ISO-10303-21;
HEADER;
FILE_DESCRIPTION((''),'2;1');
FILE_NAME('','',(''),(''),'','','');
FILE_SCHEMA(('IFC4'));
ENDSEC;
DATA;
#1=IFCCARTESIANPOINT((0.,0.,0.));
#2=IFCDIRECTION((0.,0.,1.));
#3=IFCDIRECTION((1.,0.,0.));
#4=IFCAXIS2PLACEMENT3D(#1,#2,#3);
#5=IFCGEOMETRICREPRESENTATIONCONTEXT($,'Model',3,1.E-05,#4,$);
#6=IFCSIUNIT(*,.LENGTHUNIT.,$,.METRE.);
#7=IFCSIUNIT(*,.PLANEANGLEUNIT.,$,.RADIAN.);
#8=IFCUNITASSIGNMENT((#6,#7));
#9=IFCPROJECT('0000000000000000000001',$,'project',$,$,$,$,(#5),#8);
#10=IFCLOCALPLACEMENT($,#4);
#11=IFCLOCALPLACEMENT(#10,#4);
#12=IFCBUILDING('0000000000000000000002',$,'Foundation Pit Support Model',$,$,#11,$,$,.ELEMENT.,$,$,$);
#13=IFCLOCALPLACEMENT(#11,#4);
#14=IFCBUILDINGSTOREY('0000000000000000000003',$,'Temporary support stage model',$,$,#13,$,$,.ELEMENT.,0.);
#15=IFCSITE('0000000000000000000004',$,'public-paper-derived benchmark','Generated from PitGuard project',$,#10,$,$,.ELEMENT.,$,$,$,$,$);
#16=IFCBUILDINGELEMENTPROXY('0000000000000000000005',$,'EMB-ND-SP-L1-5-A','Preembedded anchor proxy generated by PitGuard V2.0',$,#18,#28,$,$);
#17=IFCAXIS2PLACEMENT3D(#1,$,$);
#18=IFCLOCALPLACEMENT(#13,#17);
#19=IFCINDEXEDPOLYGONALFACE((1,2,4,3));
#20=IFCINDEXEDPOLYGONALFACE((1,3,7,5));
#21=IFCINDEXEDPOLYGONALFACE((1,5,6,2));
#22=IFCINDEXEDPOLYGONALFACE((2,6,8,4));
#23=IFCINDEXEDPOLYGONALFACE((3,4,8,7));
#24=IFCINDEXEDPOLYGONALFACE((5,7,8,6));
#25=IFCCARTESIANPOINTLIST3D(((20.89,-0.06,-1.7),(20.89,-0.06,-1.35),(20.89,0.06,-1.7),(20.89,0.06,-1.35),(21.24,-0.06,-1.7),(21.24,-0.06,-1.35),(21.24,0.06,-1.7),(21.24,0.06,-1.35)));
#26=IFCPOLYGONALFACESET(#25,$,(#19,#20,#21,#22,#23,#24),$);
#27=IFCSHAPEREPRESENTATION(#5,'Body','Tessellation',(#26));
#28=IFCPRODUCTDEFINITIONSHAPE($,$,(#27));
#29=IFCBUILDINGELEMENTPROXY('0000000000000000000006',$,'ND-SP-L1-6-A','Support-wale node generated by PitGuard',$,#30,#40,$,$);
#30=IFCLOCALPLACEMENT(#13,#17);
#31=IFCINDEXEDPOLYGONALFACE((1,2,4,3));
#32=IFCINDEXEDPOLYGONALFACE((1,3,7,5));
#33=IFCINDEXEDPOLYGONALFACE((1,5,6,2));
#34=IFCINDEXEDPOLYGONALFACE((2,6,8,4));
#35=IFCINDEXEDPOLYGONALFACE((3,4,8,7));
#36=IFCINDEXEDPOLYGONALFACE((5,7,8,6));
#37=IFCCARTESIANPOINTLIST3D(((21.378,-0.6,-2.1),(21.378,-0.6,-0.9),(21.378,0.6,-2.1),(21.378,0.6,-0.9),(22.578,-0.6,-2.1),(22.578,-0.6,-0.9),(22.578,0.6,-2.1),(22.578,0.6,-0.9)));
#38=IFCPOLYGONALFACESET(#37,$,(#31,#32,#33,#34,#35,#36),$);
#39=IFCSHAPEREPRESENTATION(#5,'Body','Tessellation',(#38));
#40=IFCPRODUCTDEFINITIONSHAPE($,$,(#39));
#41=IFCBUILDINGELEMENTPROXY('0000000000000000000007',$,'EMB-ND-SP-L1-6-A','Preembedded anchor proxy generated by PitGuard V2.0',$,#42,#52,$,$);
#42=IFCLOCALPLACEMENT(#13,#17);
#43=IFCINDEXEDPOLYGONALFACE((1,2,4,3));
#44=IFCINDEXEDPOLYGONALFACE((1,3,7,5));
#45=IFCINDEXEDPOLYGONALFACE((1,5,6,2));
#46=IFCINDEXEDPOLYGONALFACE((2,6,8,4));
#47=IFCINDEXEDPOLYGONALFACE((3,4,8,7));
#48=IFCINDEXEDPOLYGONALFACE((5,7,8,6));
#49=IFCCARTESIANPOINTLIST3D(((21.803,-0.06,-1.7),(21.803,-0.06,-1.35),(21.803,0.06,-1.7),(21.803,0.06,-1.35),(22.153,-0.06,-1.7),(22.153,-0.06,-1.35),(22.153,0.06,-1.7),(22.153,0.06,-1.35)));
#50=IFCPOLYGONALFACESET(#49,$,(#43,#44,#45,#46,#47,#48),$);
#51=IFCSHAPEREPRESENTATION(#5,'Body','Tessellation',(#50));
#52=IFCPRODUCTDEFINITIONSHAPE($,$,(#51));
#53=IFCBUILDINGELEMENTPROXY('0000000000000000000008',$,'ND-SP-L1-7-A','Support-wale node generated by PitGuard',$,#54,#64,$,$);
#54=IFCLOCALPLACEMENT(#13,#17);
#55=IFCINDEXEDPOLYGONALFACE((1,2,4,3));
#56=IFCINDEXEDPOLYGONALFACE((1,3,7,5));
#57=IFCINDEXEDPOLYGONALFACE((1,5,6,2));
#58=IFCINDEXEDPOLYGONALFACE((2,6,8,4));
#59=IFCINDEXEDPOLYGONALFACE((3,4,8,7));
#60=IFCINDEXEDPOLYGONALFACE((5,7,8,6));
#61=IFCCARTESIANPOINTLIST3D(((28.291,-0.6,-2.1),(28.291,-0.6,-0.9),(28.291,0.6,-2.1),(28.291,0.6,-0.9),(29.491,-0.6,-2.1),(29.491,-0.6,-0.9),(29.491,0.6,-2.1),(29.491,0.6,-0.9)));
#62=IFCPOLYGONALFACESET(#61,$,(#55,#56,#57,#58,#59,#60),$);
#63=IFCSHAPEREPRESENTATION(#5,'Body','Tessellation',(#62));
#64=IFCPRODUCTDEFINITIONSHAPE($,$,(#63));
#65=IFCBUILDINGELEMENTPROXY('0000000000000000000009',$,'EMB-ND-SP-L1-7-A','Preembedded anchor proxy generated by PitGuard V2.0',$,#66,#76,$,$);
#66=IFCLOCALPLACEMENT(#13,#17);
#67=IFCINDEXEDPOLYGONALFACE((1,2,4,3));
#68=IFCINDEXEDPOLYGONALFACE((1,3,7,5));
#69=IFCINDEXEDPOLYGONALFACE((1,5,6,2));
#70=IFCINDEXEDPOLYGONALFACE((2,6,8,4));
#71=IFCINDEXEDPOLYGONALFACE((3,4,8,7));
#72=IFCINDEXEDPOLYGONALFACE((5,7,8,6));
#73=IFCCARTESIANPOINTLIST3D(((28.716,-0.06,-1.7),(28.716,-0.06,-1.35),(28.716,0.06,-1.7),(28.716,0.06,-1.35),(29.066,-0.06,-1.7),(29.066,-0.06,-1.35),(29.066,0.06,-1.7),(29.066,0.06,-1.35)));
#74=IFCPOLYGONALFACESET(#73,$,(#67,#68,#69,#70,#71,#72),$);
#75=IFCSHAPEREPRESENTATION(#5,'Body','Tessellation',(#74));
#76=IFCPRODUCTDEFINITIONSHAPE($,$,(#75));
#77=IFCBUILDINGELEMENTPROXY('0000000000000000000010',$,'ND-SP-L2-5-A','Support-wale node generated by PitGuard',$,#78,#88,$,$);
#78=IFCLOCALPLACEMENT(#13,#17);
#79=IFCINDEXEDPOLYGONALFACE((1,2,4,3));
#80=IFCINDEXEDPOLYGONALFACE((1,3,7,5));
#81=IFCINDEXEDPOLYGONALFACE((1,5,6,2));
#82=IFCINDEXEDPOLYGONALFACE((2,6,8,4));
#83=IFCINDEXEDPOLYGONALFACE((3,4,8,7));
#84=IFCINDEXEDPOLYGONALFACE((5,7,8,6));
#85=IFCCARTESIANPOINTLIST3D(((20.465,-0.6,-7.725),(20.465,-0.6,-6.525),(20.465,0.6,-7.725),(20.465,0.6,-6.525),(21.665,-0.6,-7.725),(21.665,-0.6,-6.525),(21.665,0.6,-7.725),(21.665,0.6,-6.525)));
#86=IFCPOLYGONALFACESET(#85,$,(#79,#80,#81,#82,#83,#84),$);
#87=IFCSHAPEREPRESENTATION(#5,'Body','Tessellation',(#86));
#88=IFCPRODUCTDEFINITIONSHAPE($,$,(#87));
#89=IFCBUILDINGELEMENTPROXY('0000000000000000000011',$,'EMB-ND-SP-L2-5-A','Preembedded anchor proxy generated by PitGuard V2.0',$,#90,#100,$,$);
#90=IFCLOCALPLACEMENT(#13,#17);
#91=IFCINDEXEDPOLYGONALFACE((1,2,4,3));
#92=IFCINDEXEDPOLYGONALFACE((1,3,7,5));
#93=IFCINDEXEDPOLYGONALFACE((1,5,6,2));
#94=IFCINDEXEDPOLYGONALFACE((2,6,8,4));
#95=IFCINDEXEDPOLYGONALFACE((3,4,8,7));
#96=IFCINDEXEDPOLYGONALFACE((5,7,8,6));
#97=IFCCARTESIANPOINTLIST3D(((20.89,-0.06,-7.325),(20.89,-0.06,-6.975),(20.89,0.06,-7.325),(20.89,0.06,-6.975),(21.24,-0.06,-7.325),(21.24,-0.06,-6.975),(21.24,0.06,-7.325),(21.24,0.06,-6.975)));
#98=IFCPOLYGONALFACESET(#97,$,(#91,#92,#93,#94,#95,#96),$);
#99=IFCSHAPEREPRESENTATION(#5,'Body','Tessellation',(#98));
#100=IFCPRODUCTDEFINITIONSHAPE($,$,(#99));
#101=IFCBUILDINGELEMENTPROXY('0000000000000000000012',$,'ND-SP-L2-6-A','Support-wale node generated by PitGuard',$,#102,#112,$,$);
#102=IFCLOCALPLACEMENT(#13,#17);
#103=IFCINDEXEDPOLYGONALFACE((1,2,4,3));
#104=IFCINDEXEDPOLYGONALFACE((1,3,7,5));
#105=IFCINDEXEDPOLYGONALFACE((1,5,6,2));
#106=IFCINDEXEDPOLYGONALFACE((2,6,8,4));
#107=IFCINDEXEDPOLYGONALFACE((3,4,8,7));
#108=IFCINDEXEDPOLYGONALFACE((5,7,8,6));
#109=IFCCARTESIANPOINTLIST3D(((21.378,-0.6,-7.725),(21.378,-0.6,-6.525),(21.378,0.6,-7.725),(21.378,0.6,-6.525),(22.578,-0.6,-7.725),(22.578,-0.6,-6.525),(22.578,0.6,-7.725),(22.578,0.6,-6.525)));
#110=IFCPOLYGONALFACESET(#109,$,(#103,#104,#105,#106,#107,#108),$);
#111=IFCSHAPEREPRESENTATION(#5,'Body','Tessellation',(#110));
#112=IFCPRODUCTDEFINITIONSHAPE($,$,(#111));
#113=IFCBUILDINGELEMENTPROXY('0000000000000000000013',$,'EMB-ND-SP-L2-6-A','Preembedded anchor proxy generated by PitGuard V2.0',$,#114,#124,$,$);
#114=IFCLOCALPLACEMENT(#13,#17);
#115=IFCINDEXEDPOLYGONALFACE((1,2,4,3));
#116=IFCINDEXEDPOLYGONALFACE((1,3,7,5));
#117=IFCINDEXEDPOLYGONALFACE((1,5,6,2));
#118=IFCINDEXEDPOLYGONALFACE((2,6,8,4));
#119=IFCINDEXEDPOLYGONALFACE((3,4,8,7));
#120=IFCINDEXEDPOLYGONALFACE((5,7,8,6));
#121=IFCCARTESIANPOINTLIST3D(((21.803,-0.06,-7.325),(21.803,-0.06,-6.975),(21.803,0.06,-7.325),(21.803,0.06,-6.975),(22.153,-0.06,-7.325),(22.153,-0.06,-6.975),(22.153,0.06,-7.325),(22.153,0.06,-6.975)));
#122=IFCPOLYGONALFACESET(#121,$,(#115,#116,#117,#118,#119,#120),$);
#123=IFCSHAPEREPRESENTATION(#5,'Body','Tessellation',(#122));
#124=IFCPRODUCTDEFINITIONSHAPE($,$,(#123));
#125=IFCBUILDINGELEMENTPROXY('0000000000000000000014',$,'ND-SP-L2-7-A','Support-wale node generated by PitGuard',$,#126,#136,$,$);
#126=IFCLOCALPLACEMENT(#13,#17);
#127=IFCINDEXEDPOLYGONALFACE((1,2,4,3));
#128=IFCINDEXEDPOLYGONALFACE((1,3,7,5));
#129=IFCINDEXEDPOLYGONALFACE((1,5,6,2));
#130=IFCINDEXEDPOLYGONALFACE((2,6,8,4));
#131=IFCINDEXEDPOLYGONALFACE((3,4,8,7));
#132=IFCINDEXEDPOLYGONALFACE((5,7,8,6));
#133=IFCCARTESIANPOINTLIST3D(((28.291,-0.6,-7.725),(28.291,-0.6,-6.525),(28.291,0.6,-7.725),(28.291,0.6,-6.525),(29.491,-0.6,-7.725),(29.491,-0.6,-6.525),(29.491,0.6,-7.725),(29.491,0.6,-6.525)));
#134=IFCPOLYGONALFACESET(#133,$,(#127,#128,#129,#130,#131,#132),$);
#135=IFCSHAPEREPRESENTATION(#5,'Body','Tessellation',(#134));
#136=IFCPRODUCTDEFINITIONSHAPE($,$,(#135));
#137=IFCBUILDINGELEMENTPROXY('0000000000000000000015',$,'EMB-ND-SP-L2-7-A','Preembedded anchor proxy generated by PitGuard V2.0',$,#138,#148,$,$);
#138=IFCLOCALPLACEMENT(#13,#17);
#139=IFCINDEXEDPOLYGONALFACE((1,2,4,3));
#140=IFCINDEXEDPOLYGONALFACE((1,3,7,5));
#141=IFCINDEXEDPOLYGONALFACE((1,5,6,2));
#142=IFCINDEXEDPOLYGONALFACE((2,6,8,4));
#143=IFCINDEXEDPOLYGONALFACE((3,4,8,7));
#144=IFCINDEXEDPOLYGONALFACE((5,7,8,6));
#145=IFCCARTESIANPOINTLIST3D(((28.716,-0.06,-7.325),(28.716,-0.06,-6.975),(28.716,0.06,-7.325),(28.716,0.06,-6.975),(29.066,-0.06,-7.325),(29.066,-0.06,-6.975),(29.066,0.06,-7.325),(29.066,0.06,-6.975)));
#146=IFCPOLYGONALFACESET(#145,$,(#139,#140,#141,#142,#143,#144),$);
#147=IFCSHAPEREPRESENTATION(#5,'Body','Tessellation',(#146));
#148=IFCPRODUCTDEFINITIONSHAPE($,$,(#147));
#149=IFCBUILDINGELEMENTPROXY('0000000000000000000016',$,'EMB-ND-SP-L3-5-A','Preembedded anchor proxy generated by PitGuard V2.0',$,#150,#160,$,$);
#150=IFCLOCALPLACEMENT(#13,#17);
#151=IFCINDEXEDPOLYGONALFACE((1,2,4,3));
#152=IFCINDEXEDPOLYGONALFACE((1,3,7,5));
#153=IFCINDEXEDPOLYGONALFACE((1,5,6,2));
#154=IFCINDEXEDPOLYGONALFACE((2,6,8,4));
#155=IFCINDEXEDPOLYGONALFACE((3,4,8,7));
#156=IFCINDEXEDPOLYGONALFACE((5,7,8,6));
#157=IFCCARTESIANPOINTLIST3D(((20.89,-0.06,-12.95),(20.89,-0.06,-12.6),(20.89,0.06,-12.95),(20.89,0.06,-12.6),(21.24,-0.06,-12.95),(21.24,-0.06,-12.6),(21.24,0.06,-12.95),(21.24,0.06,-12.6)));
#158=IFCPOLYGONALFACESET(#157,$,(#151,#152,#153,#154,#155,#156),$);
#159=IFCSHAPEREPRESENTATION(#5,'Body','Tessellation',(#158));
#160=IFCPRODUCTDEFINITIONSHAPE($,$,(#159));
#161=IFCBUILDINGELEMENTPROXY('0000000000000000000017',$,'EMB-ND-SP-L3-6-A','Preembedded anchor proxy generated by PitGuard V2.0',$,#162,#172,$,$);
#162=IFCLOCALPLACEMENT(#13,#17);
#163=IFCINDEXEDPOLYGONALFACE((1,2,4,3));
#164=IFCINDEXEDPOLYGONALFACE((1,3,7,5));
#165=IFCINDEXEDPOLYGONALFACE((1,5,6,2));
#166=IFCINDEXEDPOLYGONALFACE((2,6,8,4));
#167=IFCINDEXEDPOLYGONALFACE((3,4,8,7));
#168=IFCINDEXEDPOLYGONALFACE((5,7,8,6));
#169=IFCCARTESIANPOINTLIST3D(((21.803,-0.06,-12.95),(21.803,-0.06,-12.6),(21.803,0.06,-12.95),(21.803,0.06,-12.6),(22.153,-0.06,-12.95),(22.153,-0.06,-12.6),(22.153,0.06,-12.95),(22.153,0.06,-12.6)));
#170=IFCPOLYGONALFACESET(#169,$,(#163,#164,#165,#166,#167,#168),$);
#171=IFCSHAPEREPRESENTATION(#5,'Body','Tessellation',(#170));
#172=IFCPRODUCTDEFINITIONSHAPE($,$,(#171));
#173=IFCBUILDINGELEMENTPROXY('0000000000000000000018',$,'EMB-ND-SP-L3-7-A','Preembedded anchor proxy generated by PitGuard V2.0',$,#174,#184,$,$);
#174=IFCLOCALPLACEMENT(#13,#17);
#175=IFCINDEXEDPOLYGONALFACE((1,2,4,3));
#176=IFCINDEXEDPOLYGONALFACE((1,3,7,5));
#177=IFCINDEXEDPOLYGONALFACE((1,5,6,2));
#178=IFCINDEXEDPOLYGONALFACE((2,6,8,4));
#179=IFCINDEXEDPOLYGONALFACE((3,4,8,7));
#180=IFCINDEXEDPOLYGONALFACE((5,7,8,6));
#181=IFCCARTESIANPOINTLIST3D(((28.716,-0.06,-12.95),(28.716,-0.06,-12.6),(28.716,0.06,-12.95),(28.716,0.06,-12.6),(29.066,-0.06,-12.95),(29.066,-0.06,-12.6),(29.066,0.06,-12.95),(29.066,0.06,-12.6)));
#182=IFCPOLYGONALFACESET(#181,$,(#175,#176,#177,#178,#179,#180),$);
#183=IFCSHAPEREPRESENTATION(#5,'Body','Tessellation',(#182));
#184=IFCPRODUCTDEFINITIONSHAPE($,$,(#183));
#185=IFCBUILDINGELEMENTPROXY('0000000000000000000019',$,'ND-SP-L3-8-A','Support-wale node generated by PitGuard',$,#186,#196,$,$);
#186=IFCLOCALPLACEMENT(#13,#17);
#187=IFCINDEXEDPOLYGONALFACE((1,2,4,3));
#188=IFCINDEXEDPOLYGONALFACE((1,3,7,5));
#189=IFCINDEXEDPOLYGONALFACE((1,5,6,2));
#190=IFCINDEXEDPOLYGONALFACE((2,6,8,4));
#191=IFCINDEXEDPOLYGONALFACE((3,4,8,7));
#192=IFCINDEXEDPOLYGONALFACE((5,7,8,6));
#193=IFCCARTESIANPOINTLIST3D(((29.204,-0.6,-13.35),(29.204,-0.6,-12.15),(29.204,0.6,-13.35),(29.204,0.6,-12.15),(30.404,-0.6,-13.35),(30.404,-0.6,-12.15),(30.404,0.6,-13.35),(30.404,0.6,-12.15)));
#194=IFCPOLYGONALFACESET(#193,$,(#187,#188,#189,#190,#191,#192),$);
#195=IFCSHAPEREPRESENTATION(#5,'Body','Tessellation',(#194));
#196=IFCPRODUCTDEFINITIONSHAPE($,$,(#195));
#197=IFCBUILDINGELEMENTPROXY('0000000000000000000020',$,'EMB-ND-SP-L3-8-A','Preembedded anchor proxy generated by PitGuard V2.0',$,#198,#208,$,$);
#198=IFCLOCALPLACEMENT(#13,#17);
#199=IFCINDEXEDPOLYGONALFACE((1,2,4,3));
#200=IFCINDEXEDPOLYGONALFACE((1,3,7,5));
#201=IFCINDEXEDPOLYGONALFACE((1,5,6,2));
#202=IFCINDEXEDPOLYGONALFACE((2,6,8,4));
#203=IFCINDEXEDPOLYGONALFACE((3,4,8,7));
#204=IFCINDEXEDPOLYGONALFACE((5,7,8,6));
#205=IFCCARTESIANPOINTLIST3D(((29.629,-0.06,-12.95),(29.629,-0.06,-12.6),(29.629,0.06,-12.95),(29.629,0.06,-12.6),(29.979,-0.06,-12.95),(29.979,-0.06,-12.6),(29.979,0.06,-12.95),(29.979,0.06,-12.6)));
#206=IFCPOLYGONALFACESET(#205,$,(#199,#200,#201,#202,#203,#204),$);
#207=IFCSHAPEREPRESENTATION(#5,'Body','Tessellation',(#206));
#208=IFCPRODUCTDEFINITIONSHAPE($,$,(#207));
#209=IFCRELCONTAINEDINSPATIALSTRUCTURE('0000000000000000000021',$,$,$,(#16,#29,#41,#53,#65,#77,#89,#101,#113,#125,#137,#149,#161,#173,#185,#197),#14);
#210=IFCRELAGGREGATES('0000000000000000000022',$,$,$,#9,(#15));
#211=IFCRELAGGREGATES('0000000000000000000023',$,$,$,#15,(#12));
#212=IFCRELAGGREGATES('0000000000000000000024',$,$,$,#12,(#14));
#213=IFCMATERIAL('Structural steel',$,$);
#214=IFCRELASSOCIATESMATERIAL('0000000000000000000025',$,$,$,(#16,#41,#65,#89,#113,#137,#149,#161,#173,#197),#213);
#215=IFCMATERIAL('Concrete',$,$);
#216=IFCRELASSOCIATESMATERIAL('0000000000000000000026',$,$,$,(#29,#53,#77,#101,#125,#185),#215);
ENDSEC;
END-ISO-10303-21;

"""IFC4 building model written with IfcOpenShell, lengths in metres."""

from ifc_helpers import new_model, si_unit, frame, origin_with_axes, origin_2d, place, context, project, spatial, rectangle, extrude, material, element, save


model = new_model("IFC4")

# Units and contexts
model_context = context("Model", 3, precision=1e-05, world=origin_with_axes())
ifc_project = project(units=[si_unit("LENGTHUNIT", "METRE"), si_unit("PLANEANGLEUNIT", "RADIAN")], contexts=[model_context])

# Site, building, storey
site_placement = place(None, origin_with_axes())
site = spatial("IfcSite", under=ifc_project, at=site_placement, Name="public-paper-derived benchmark", Description="Generated from PitGuard project", CompositionType="ELEMENT")
building_placement = place(site_placement, origin_with_axes())
building = spatial("IfcBuilding", under=site, at=building_placement, Name="Foundation Pit Support Model", CompositionType="ELEMENT")
storey_placement = place(building_placement, origin_with_axes())
storey = spatial("IfcBuildingStorey", under=building, at=storey_placement, Name="Temporary support stage model", CompositionType="ELEMENT", Elevation=0.0)

# Shared definitions
ifc_material_1 = material(Name="Concrete")

# Shared definitions
ifc_material_2 = material(Name="Structural steel")

# Building element proxies
proxy_1_placement = place(storey_placement, frame((21.065, 0.0, -1.7), z_axis=(0.0, 0.0, 1.0), x_axis=(1.0, 0.0, 0.0)))
element("IfcBuildingElementProxy", 1, at=proxy_1_placement, inside=storey, material=ifc_material_2, Name="EMB-ND-SP-L1-5-A", Description="Preembedded anchor proxy generated by PitGuard V2.0", context=model_context, shape_type="SweptSolid", body=[
    extrude(rectangle(XDim=0.35, YDim=0.12, at=origin_2d()), origin_with_axes(), (0.0, 0.0, 1.0), 0.35),
])
proxy_2_placement = place(storey_placement, frame((21.978, 0.0, -2.1), z_axis=(0.0, 0.0, 1.0), x_axis=(1.0, 0.0, 0.0)))
element("IfcBuildingElementProxy", 2, at=proxy_2_placement, inside=storey, material=ifc_material_1, Name="ND-SP-L1-6-A", Description="Support-wale node generated by PitGuard", context=model_context, shape_type="SweptSolid", body=[
    extrude(rectangle(XDim=1.2, YDim=1.2, at=origin_2d()), origin_with_axes(), (0.0, 0.0, 1.0), 1.2),
])
proxy_3_placement = place(storey_placement, frame((21.978, 0.0, -1.7), z_axis=(0.0, 0.0, 1.0), x_axis=(1.0, 0.0, 0.0)))
element("IfcBuildingElementProxy", 3, at=proxy_3_placement, inside=storey, material=ifc_material_2, Name="EMB-ND-SP-L1-6-A", Description="Preembedded anchor proxy generated by PitGuard V2.0", context=model_context, shape_type="SweptSolid", body=[
    extrude(rectangle(XDim=0.35, YDim=0.12, at=origin_2d()), origin_with_axes(), (0.0, 0.0, 1.0), 0.35),
])
proxy_4_placement = place(storey_placement, frame((28.891, 0.0, -2.1), z_axis=(0.0, 0.0, 1.0), x_axis=(1.0, 0.0, 0.0)))
element("IfcBuildingElementProxy", 4, at=proxy_4_placement, inside=storey, material=ifc_material_1, Name="ND-SP-L1-7-A", Description="Support-wale node generated by PitGuard", context=model_context, shape_type="SweptSolid", body=[
    extrude(rectangle(XDim=1.2, YDim=1.2, at=origin_2d()), origin_with_axes(), (0.0, 0.0, 1.0), 1.2),
])
proxy_5_placement = place(storey_placement, frame((28.891, 0.0, -1.7), z_axis=(0.0, 0.0, 1.0), x_axis=(1.0, 0.0, 0.0)))
element("IfcBuildingElementProxy", 5, at=proxy_5_placement, inside=storey, material=ifc_material_2, Name="EMB-ND-SP-L1-7-A", Description="Preembedded anchor proxy generated by PitGuard V2.0", context=model_context, shape_type="SweptSolid", body=[
    extrude(rectangle(XDim=0.35, YDim=0.12, at=origin_2d()), origin_with_axes(), (0.0, 0.0, 1.0), 0.35),
])
proxy_6_placement = place(storey_placement, frame((21.065, 0.0, -7.725), z_axis=(0.0, 0.0, 1.0), x_axis=(1.0, 0.0, 0.0)))
element("IfcBuildingElementProxy", 6, at=proxy_6_placement, inside=storey, material=ifc_material_1, Name="ND-SP-L2-5-A", Description="Support-wale node generated by PitGuard", context=model_context, shape_type="SweptSolid", body=[
    extrude(rectangle(XDim=1.2, YDim=1.2, at=origin_2d()), origin_with_axes(), (0.0, 0.0, 1.0), 1.2),
])
proxy_7_placement = place(storey_placement, frame((21.065, 0.0, -7.325), z_axis=(0.0, 0.0, 1.0), x_axis=(1.0, 0.0, 0.0)))
element("IfcBuildingElementProxy", 7, at=proxy_7_placement, inside=storey, material=ifc_material_2, Name="EMB-ND-SP-L2-5-A", Description="Preembedded anchor proxy generated by PitGuard V2.0", context=model_context, shape_type="SweptSolid", body=[
    extrude(rectangle(XDim=0.35, YDim=0.12, at=origin_2d()), origin_with_axes(), (0.0, 0.0, 1.0), 0.35),
])
proxy_8_placement = place(storey_placement, frame((21.978, 0.0, -7.725), z_axis=(0.0, 0.0, 1.0), x_axis=(1.0, 0.0, 0.0)))
element("IfcBuildingElementProxy", 8, at=proxy_8_placement, inside=storey, material=ifc_material_1, Name="ND-SP-L2-6-A", Description="Support-wale node generated by PitGuard", context=model_context, shape_type="SweptSolid", body=[
    extrude(rectangle(XDim=1.2, YDim=1.2, at=origin_2d()), origin_with_axes(), (0.0, 0.0, 1.0), 1.2),
])
proxy_9_placement = place(storey_placement, frame((21.978, 0.0, -7.325), z_axis=(0.0, 0.0, 1.0), x_axis=(1.0, 0.0, 0.0)))
element("IfcBuildingElementProxy", 9, at=proxy_9_placement, inside=storey, material=ifc_material_2, Name="EMB-ND-SP-L2-6-A", Description="Preembedded anchor proxy generated by PitGuard V2.0", context=model_context, shape_type="SweptSolid", body=[
    extrude(rectangle(XDim=0.35, YDim=0.12, at=origin_2d()), origin_with_axes(), (0.0, 0.0, 1.0), 0.35),
])
proxy_10_placement = place(storey_placement, frame((28.891, 0.0, -7.725), z_axis=(0.0, 0.0, 1.0), x_axis=(1.0, 0.0, 0.0)))
element("IfcBuildingElementProxy", 10, at=proxy_10_placement, inside=storey, material=ifc_material_1, Name="ND-SP-L2-7-A", Description="Support-wale node generated by PitGuard", context=model_context, shape_type="SweptSolid", body=[
    extrude(rectangle(XDim=1.2, YDim=1.2, at=origin_2d()), origin_with_axes(), (0.0, 0.0, 1.0), 1.2),
])
for number, where, z_axis, x_axis, name in (
    (11, (28.891, 0.0, -7.325), (0.0, 0.0, 1.0), (1.0, 0.0, 0.0), "EMB-ND-SP-L2-7-A"),
    (12, (21.065, 0.0, -12.95), (0.0, 0.0, 1.0), (1.0, 0.0, 0.0), "EMB-ND-SP-L3-5-A"),
    (13, (21.978, 0.0, -12.95), (0.0, 0.0, 1.0), (1.0, 0.0, 0.0), "EMB-ND-SP-L3-6-A"),
    (14, (28.891, 0.0, -12.95), (0.0, 0.0, 1.0), (1.0, 0.0, 0.0), "EMB-ND-SP-L3-7-A"),
):
    element("IfcBuildingElementProxy", number, at=place(storey_placement, frame(where, z_axis=z_axis, x_axis=x_axis)), inside=storey, material=ifc_material_2, Name=name, Description="Preembedded anchor proxy generated by PitGuard V2.0", context=model_context, shape_type="SweptSolid", body=[
        extrude(rectangle(XDim=0.35, YDim=0.12, at=origin_2d()), origin_with_axes(), (0.0, 0.0, 1.0), 0.35),
    ])
proxy_11_placement = place(storey_placement, frame((29.804, 0.0, -13.35), z_axis=(0.0, 0.0, 1.0), x_axis=(1.0, 0.0, 0.0)))
element("IfcBuildingElementProxy", 15, at=proxy_11_placement, inside=storey, material=ifc_material_1, Name="ND-SP-L3-8-A", Description="Support-wale node generated by PitGuard", context=model_context, shape_type="SweptSolid", body=[
    extrude(rectangle(XDim=1.2, YDim=1.2, at=origin_2d()), origin_with_axes(), (0.0, 0.0, 1.0), 1.2),
])
proxy_12_placement = place(storey_placement, frame((29.804, 0.0, -12.95), z_axis=(0.0, 0.0, 1.0), x_axis=(1.0, 0.0, 0.0)))
element("IfcBuildingElementProxy", 16, at=proxy_12_placement, inside=storey, material=ifc_material_2, Name="EMB-ND-SP-L3-8-A", Description="Preembedded anchor proxy generated by PitGuard V2.0", context=model_context, shape_type="SweptSolid", body=[
    extrude(rectangle(XDim=0.35, YDim=0.12, at=origin_2d()), origin_with_axes(), (0.0, 0.0, 1.0), 0.35),
])

save(model, "model.ifc")
